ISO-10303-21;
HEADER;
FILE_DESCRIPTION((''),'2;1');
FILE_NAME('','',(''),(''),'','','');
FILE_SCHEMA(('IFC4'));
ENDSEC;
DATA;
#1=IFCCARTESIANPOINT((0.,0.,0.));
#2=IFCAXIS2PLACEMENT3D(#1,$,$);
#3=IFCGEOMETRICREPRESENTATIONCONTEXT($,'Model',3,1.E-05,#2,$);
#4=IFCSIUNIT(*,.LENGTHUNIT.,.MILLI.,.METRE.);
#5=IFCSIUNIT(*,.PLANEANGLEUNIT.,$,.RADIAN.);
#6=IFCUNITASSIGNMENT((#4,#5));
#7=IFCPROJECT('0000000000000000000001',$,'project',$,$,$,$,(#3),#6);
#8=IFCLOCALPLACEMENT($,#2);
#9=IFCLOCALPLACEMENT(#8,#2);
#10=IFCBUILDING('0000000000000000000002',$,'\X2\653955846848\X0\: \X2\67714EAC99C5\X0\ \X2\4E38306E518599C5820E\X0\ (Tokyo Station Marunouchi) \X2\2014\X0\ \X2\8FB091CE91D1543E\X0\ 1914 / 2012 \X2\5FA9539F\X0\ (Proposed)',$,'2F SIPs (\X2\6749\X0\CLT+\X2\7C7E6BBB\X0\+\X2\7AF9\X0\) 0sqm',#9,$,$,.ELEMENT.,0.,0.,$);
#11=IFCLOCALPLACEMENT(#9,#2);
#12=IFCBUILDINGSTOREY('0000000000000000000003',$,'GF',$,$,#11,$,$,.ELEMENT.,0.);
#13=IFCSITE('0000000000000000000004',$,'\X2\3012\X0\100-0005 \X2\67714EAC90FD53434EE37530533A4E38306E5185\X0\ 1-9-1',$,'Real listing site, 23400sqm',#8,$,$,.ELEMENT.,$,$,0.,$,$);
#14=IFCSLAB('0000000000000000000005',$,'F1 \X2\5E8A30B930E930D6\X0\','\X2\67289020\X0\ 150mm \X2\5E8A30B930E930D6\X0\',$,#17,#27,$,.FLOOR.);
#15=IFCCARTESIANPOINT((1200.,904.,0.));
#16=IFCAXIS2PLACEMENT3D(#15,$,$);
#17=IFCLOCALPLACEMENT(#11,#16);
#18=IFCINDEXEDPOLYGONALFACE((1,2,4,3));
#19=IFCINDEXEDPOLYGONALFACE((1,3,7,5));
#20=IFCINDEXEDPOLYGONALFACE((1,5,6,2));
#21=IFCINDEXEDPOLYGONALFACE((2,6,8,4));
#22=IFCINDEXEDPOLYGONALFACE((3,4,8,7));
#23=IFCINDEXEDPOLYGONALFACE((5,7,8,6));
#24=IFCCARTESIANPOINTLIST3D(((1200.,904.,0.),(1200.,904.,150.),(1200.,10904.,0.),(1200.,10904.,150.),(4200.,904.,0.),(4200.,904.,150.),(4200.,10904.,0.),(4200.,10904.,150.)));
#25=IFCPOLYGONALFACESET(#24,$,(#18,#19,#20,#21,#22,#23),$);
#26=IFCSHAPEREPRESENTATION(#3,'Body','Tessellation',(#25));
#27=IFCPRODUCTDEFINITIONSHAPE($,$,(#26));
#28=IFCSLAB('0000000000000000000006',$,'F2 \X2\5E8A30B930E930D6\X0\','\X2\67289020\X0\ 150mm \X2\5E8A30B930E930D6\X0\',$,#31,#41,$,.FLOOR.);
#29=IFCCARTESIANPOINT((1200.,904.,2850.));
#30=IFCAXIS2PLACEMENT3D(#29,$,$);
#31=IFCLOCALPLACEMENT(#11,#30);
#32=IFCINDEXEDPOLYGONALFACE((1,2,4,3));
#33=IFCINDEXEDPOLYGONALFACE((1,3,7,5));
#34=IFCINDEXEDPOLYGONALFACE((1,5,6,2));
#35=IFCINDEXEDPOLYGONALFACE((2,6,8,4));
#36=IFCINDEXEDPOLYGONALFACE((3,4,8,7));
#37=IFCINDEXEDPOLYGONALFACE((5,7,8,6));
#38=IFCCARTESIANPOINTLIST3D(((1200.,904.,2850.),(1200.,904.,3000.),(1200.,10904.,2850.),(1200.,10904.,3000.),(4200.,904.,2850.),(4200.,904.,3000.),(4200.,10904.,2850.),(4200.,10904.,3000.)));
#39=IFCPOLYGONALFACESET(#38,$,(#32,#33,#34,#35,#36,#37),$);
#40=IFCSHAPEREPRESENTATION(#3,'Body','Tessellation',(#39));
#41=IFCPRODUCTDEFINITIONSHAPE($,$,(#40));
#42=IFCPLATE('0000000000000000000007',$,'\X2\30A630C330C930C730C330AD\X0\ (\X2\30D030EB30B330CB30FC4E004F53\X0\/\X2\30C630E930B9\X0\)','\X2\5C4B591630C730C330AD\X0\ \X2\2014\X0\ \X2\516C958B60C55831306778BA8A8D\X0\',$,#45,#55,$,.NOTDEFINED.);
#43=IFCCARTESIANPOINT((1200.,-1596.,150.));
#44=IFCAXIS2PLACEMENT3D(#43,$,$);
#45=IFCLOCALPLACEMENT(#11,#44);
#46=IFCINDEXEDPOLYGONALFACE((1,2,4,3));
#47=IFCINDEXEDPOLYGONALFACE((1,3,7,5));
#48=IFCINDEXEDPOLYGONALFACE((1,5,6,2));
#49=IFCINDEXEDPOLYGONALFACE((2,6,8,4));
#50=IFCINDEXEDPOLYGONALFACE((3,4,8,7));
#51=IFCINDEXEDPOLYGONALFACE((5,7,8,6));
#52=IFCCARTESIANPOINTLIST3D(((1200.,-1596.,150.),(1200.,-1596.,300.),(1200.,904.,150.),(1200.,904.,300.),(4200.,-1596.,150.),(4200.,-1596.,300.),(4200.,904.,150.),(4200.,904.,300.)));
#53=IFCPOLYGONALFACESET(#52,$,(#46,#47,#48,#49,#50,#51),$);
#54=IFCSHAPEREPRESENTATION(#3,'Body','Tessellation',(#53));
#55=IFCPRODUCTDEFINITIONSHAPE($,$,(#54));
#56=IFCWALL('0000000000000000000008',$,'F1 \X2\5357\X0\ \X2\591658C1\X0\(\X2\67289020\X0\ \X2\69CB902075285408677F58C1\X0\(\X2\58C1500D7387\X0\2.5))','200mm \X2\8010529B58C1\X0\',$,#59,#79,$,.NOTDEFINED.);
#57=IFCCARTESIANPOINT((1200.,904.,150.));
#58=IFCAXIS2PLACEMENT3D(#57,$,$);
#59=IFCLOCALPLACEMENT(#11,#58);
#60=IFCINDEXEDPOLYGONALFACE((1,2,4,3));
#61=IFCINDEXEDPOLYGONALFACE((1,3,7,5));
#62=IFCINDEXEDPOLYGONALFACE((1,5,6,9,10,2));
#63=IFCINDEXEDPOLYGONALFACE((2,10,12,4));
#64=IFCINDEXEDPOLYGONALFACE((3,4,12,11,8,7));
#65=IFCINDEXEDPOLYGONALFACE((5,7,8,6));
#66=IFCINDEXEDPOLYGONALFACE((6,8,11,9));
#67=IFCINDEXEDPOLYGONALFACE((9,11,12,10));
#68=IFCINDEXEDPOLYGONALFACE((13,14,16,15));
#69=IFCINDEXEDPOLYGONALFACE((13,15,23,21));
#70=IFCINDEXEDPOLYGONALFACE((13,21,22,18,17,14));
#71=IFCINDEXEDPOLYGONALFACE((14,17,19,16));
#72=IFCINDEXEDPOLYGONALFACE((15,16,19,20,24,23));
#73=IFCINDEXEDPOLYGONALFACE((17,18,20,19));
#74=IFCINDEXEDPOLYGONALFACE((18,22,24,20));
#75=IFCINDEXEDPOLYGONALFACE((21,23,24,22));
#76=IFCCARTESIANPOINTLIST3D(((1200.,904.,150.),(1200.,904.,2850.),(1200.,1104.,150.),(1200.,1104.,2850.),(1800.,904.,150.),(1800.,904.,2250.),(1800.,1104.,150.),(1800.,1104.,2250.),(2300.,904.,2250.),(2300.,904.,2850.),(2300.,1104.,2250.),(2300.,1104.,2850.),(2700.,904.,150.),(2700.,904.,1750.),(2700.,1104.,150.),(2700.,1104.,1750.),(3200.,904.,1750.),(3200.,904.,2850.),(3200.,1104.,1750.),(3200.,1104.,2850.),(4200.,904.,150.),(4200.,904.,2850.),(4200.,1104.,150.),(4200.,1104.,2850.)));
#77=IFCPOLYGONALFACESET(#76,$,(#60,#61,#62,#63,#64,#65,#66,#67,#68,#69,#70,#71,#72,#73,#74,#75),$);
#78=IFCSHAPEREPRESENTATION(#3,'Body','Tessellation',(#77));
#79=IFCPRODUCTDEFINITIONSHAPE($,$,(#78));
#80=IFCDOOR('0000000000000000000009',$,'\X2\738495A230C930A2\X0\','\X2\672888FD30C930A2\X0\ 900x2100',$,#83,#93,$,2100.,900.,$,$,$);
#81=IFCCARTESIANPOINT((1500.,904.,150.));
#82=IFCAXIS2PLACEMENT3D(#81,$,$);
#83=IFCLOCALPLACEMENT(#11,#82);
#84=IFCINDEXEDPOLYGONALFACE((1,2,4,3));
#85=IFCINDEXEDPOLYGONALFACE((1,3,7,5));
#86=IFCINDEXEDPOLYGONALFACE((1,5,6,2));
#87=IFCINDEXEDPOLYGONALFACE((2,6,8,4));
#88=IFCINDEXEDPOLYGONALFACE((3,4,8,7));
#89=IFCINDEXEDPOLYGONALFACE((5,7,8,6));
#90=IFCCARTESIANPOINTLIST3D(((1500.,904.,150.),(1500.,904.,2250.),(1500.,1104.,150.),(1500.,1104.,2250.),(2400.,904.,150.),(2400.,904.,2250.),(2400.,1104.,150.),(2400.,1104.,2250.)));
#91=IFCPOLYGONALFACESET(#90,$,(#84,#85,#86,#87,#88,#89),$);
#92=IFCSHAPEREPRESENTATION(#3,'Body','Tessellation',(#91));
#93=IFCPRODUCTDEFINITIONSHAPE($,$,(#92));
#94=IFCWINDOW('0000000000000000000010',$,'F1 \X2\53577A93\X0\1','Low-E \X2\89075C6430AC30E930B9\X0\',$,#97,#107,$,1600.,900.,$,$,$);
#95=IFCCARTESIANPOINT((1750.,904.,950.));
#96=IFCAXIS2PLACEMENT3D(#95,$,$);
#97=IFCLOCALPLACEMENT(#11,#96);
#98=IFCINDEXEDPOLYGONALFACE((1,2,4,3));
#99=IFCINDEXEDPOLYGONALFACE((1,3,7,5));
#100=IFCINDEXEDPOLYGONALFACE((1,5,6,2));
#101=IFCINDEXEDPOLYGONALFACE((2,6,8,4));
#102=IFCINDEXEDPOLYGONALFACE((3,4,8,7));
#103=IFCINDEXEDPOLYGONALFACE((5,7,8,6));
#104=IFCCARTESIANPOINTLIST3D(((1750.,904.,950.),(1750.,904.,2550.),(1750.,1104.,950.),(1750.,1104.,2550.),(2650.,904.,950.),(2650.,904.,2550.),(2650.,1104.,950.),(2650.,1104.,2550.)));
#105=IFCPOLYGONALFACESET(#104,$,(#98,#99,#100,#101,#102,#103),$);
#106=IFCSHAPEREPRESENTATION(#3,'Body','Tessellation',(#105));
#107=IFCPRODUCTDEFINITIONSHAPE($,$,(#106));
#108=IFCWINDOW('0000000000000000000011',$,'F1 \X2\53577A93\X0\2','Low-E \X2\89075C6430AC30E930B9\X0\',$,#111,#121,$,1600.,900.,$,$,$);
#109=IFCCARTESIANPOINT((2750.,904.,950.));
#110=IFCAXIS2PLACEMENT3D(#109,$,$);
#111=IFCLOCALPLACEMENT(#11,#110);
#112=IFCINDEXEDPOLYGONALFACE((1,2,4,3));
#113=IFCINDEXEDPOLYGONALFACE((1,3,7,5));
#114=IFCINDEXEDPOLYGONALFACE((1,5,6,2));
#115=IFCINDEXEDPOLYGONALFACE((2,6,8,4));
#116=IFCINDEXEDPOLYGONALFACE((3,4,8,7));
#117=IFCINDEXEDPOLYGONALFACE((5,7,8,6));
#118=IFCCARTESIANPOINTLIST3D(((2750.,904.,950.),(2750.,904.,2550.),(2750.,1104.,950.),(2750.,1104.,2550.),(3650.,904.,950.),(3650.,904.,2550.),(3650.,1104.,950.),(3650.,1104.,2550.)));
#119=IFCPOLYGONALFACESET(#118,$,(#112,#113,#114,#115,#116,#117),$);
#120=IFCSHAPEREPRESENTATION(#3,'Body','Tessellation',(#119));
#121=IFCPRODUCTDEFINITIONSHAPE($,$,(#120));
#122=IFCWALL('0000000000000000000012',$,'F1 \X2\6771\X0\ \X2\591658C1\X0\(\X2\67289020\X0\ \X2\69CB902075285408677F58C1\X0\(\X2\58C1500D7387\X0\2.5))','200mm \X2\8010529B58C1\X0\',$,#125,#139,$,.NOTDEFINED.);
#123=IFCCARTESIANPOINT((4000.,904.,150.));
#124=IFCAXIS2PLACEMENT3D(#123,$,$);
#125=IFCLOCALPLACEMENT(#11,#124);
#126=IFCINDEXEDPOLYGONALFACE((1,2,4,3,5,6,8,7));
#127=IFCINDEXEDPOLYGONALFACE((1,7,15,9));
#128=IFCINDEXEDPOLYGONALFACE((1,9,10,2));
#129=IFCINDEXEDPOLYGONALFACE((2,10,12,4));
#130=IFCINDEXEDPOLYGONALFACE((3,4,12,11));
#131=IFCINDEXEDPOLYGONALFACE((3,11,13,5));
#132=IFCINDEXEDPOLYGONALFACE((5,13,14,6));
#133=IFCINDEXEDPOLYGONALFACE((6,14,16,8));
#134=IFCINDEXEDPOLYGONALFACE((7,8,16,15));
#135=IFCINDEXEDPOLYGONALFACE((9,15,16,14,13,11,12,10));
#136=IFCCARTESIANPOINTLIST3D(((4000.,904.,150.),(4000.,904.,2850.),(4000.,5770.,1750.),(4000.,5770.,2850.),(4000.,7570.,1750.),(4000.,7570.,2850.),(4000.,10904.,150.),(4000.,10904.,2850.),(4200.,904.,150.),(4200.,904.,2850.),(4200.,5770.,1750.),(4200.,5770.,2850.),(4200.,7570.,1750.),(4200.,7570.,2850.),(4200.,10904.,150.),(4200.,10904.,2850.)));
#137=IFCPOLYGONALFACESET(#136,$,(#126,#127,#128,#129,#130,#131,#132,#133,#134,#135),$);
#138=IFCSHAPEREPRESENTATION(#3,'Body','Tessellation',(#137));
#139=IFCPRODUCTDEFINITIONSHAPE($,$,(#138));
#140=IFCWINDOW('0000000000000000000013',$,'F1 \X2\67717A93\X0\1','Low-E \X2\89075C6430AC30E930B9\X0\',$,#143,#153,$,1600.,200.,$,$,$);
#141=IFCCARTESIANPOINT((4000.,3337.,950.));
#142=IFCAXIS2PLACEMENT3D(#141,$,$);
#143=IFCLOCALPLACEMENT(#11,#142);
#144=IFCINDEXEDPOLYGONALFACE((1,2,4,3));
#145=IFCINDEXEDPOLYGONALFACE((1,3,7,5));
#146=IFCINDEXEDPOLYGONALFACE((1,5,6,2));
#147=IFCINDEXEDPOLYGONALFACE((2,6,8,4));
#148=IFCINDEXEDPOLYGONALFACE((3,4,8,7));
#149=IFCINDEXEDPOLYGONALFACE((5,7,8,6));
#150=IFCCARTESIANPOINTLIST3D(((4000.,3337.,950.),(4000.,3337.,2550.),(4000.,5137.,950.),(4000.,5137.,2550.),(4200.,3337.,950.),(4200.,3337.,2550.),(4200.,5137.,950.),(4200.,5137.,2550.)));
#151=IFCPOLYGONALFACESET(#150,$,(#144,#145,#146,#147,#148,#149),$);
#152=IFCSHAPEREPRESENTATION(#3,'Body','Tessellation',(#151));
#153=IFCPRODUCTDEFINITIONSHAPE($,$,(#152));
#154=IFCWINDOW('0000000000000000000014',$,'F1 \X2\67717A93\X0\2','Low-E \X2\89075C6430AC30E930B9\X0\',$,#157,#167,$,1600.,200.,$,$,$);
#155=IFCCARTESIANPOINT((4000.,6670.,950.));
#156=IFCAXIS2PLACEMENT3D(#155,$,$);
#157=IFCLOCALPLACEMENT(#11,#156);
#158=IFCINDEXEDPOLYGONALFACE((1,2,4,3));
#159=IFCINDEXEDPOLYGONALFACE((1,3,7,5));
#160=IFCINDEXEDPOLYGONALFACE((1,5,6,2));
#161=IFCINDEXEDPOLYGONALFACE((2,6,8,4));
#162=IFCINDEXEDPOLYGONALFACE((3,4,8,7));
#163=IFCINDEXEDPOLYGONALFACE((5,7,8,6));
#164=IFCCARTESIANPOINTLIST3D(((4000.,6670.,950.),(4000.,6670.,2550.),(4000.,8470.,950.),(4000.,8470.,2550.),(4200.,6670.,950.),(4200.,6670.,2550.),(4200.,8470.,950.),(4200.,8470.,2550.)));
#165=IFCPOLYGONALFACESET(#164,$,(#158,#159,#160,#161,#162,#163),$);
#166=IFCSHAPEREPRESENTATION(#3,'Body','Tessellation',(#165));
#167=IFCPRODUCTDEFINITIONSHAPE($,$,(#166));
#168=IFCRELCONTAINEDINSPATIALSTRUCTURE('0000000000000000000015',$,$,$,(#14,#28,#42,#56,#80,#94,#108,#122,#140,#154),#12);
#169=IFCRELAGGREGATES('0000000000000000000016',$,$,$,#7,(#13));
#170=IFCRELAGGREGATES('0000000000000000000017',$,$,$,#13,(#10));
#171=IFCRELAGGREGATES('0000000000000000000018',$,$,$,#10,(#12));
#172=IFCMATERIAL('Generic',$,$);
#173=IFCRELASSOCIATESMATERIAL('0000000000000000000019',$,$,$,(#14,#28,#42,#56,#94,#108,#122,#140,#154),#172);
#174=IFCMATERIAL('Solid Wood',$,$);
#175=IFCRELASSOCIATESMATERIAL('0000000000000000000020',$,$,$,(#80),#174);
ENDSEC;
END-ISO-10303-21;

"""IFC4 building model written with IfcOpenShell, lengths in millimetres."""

from ifc_helpers import new_model, si_unit, frame, frame_2d, origin, place, context, project, spatial, rectangle, extrude, material, element, fill, save


model = new_model("IFC4")

# Units and contexts
model_context = context("Model", 3, precision=1e-05, world=origin())
ifc_project = project(units=[si_unit("LENGTHUNIT", "METRE", prefix="MILLI"), si_unit("PLANEANGLEUNIT", "RADIAN")], contexts=[model_context])

# Site, building, storey
site_placement = place(None, origin())
site = spatial("IfcSite", under=ifc_project, at=site_placement, Name="〒100-0005 東京都千代田区丸の内 1-9-1", ObjectType="Real listing site, 23400sqm", CompositionType="ELEMENT", RefElevation=0.0)
building_placement = place(site_placement, origin())
building = spatial("IfcBuilding", under=site, at=building_placement, Name="改善案: 東京駅 丸の内駅舎 (Tokyo Station Marunouchi) — 辰野金吾 1914 / 2012 復原 (Proposed)", ObjectType="2F SIPs (杉CLT+籾殻+竹) 0sqm", CompositionType="ELEMENT", ElevationOfRefHeight=0.0, ElevationOfTerrain=0.0)
storey_placement = place(building_placement, origin())
storey = spatial("IfcBuildingStorey", under=building, at=storey_placement, Name="GF", CompositionType="ELEMENT", Elevation=0.0)

# Slabs
ifc_material_1 = material(Name="Generic")
slab_1_placement = place(storey_placement, frame((1200.0, 904.0, 0.0)))
element("IfcSlab", 1, at=slab_1_placement, inside=storey, material=ifc_material_1, Name="F1 床スラブ", Description="木造 150mm 床スラブ", PredefinedType="FLOOR", context=model_context, shape_type="SweptSolid", body=[
    extrude(rectangle(XDim=3000.0, YDim=10000.0, at=frame_2d((1500.0, 5000.0))), frame((1200.0, 904.0, 0.0)), (0.0, 0.0, 1.0), 150.0),
])
slab_2_placement = place(storey_placement, frame((1200.0, 904.0, 2850.0)))
element("IfcSlab", 2, at=slab_2_placement, inside=storey, material=ifc_material_1, Name="F2 床スラブ", Description="木造 150mm 床スラブ", PredefinedType="FLOOR", context=model_context, shape_type="SweptSolid", body=[
    extrude(rectangle(XDim=3000.0, YDim=10000.0, at=frame_2d((1500.0, 5000.0))), frame((1200.0, 904.0, 2850.0)), (0.0, 0.0, 1.0), 150.0),
])

# Plate
plate_placement = place(storey_placement, frame((1200.0, -1596.0, 150.0)))
element("IfcPlate", 3, at=plate_placement, inside=storey, material=ifc_material_1, Name="ウッドデッキ (バルコニー一体/テラス)", Description="屋外デッキ — 公開情報で確認", PredefinedType="NOTDEFINED", context=model_context, shape_type="SweptSolid", body=[
    extrude(rectangle(XDim=3000.0, YDim=2500.0, at=frame_2d((1500.0, 1250.0))), frame((1200.0, -1596.0, 150.0)), (0.0, 0.0, 1.0), 150.0),
])

# Wall, openings, door, windows
wall_1_placement = place(storey_placement, frame((1200.0, 904.0, 150.0)))
wall_1 = element("IfcWall", 4, at=wall_1_placement, inside=storey, material=ifc_material_1, Name="F1 南 外壁(木造 構造用合板壁(壁倍率2.5))", Description="200mm 耐力壁", PredefinedType="NOTDEFINED", context=model_context, shape_type="SweptSolid", body=[
    extrude(rectangle(XDim=3000.0, YDim=200.0, at=frame_2d((1500.0, 100.0))), frame((1200.0, 904.0, 150.0)), (0.0, 0.0, 1.0), 2700.0),
])
opening_1_placement = place(storey_placement, frame((1500.0, 904.0, 150.0)))
opening_1 = element("IfcOpeningElement", 5, at=opening_1_placement, cuts=wall_1, PredefinedType="NOTDEFINED", context=model_context, shape_type="SweptSolid", body=[
    extrude(rectangle(XDim=900.0, YDim=200.0, at=frame_2d((450.0, 100.0))), frame((1500.0, 904.0, 150.0)), (0.0, 0.0, 1.0), 2100.0),
])
opening_2_placement = place(storey_placement, frame((1750.0, 904.0, 950.0)))
opening_2 = element("IfcOpeningElement", 6, at=opening_2_placement, cuts=wall_1, PredefinedType="NOTDEFINED", context=model_context, shape_type="SweptSolid", body=[
    extrude(rectangle(XDim=900.0, YDim=200.0, at=frame_2d((450.0, 100.0))), frame((1750.0, 904.0, 950.0)), (0.0, 0.0, 1.0), 1600.0),
])
opening_3_placement = place(storey_placement, frame((2750.0, 904.0, 950.0)))
opening_3 = element("IfcOpeningElement", 7, at=opening_3_placement, cuts=wall_1, PredefinedType="NOTDEFINED", context=model_context, shape_type="SweptSolid", body=[
    extrude(rectangle(XDim=900.0, YDim=200.0, at=frame_2d((450.0, 100.0))), frame((2750.0, 904.0, 950.0)), (0.0, 0.0, 1.0), 1600.0),
])
ifc_material_2 = material(Name="Solid Wood")
door_placement = place(storey_placement, frame((1500.0, 904.0, 150.0)))
door = element("IfcDoor", 8, at=door_placement, inside=storey, material=ifc_material_2, Name="玄関ドア", Description="木製ドア 900x2100", OverallHeight=2100.0, OverallWidth=900.0, context=model_context, shape_type="SweptSolid", body=[
    extrude(rectangle(XDim=900.0, YDim=200.0, at=frame_2d((450.0, 100.0))), frame((1500.0, 904.0, 150.0)), (0.0, 0.0, 1.0), 2100.0),
])
fill(opening_1, door)
window_1_placement = place(storey_placement, frame((1750.0, 904.0, 950.0)))
window_1 = element("IfcWindow", 9, at=window_1_placement, inside=storey, material=ifc_material_1, Name="F1 南窓1", Description="Low-E 複層ガラス", OverallHeight=1600.0, OverallWidth=900.0, context=model_context, shape_type="SweptSolid", body=[
    extrude(rectangle(XDim=900.0, YDim=200.0, at=frame_2d((450.0, 100.0))), frame((1750.0, 904.0, 950.0)), (0.0, 0.0, 1.0), 1600.0),
])
fill(opening_2, window_1)
window_2_placement = place(storey_placement, frame((2750.0, 904.0, 950.0)))
window_2 = element("IfcWindow", 10, at=window_2_placement, inside=storey, material=ifc_material_1, Name="F1 南窓2", Description="Low-E 複層ガラス", OverallHeight=1600.0, OverallWidth=900.0, context=model_context, shape_type="SweptSolid", body=[
    extrude(rectangle(XDim=900.0, YDim=200.0, at=frame_2d((450.0, 100.0))), frame((2750.0, 904.0, 950.0)), (0.0, 0.0, 1.0), 1600.0),
])
fill(opening_3, window_2)

# Wall, openings, windows
wall_2_placement = place(storey_placement, frame((4000.0, 904.0, 150.0)))
wall_2 = element("IfcWall", 11, at=wall_2_placement, inside=storey, material=ifc_material_1, Name="F1 東 外壁(木造 構造用合板壁(壁倍率2.5))", Description="200mm 耐力壁", PredefinedType="NOTDEFINED", context=model_context, shape_type="SweptSolid", body=[
    extrude(rectangle(XDim=200.0, YDim=10000.0, at=frame_2d((100.0, 5000.0))), frame((4000.0, 904.0, 150.0)), (0.0, 0.0, 1.0), 2700.0),
])
opening_4_placement = place(storey_placement, frame((4000.0, 3337.0, 950.0)))
opening_4 = element("IfcOpeningElement", 12, at=opening_4_placement, cuts=wall_2, PredefinedType="NOTDEFINED", context=model_context, shape_type="SweptSolid", body=[
    extrude(rectangle(XDim=200.0, YDim=1800.0, at=frame_2d((100.0, 900.0))), frame((4000.0, 3337.0, 950.0)), (0.0, 0.0, 1.0), 1600.0),
])
opening_5_placement = place(storey_placement, frame((4000.0, 6670.0, 950.0)))
opening_5 = element("IfcOpeningElement", 13, at=opening_5_placement, cuts=wall_2, PredefinedType="NOTDEFINED", context=model_context, shape_type="SweptSolid", body=[
    extrude(rectangle(XDim=200.0, YDim=1800.0, at=frame_2d((100.0, 900.0))), frame((4000.0, 6670.0, 950.0)), (0.0, 0.0, 1.0), 1600.0),
])
window_3_placement = place(storey_placement, frame((4000.0, 3337.0, 950.0)))
window_3 = element("IfcWindow", 14, at=window_3_placement, inside=storey, material=ifc_material_1, Name="F1 東窓1", Description="Low-E 複層ガラス", OverallHeight=1600.0, OverallWidth=200.0, context=model_context, shape_type="SweptSolid", body=[
    extrude(rectangle(XDim=200.0, YDim=1800.0, at=frame_2d((100.0, 900.0))), frame((4000.0, 3337.0, 950.0)), (0.0, 0.0, 1.0), 1600.0),
])
fill(opening_4, window_3)
window_4_placement = place(storey_placement, frame((4000.0, 6670.0, 950.0)))
window_4 = element("IfcWindow", 15, at=window_4_placement, inside=storey, material=ifc_material_1, Name="F1 東窓2", Description="Low-E 複層ガラス", OverallHeight=1600.0, OverallWidth=200.0, context=model_context, shape_type="SweptSolid", body=[
    extrude(rectangle(XDim=200.0, YDim=1800.0, at=frame_2d((100.0, 900.0))), frame((4000.0, 6670.0, 950.0)), (0.0, 0.0, 1.0), 1600.0),
])
fill(opening_5, window_4)

save(model, "model.ifc")
